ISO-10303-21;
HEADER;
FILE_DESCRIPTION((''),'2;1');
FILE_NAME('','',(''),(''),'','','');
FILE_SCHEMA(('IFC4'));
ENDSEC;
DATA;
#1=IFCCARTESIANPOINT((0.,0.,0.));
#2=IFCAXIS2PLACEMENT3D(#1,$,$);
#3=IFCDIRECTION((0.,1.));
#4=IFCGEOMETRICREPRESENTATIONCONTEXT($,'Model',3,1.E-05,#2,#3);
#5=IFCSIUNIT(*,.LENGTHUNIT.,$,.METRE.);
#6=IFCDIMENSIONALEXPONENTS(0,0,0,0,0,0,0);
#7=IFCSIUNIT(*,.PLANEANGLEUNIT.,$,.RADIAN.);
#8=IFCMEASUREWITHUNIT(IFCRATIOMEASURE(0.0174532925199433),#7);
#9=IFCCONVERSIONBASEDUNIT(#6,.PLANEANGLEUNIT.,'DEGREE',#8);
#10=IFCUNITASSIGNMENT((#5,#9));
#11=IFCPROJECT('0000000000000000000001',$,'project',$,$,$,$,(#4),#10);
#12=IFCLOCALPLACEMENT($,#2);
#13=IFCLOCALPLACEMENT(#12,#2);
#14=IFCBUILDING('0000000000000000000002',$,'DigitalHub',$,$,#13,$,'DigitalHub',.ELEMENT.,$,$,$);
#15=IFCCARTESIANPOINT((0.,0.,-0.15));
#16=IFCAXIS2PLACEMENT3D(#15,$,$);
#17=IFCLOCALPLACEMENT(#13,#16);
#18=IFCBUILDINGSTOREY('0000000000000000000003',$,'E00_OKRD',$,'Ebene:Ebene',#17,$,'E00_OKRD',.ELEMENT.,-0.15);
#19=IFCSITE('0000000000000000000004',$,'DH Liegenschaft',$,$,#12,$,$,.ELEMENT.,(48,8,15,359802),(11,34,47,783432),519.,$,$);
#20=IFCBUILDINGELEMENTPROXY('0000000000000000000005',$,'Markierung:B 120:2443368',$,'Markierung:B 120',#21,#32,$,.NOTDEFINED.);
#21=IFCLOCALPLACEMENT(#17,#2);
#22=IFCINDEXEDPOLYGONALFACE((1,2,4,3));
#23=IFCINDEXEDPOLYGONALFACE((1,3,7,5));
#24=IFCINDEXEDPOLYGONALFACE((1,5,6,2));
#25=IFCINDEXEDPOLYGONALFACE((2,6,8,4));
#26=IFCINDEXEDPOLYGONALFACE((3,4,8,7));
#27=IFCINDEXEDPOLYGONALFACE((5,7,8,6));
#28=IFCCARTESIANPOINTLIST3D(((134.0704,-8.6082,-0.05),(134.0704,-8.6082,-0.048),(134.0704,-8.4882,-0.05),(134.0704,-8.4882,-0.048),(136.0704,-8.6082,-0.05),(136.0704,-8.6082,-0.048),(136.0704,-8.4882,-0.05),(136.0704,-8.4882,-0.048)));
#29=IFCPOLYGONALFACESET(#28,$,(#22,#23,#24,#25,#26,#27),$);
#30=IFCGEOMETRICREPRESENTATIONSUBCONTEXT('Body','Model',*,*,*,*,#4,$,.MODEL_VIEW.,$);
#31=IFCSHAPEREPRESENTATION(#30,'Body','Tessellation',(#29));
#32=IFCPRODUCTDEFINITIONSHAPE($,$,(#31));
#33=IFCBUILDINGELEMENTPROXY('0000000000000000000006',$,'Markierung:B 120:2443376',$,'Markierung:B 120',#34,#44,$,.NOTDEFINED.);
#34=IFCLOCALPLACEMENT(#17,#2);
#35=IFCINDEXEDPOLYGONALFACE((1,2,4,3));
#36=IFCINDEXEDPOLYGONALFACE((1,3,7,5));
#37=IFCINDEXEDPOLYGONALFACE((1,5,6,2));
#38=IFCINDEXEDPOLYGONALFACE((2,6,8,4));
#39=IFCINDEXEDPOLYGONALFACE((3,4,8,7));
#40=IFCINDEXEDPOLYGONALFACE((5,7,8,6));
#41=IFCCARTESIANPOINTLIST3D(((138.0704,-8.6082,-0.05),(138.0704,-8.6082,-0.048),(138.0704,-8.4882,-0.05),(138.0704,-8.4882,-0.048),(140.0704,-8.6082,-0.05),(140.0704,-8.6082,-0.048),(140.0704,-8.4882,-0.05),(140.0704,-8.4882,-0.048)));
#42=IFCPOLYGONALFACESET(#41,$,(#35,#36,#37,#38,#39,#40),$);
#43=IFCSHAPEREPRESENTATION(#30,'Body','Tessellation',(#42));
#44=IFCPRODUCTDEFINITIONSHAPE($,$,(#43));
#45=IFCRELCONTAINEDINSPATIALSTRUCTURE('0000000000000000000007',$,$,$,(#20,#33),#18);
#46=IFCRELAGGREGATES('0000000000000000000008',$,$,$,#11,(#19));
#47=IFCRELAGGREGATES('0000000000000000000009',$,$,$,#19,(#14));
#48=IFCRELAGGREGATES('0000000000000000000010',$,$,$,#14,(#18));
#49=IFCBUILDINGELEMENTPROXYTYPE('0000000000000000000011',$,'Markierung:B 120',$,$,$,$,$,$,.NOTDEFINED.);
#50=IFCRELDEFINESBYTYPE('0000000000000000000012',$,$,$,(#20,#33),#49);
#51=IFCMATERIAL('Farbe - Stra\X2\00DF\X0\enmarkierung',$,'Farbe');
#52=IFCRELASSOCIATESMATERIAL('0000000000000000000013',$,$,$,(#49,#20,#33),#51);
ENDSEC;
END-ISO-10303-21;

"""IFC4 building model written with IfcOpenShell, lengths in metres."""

from ifc_helpers import new_model, entity, si_unit, converted_unit, direction, frame, origin, place, context, subcontext, project, spatial, indexed_curve, outline, extrude, source, transform, mapped, material, type_object, type_shapes, element, save


model = new_model("IFC4")

# Units and contexts
model_context = context("Model", 3, precision=1e-05, world=origin(), true_north=direction((0.0, 1.0)))
body_context = subcontext(model_context, "Body", "Model", "MODEL_VIEW")
ifc_project = project(units=[si_unit("LENGTHUNIT", "METRE"), converted_unit("PLANEANGLEUNIT", "DEGREE", entity("IfcRatioMeasure", 0.0174532925199433), si_unit("PLANEANGLEUNIT", "RADIAN"), dimensions=[0, 0, 0, 0, 0, 0, 0])], contexts=[model_context])

# Site, building, storey
site_placement = place(None, frame((0.0, 0.0, 0.0)))
site = spatial("IfcSite", under=ifc_project, at=site_placement, Name="DH Liegenschaft", CompositionType="ELEMENT", RefLatitude=(48, 8, 15, 359802), RefLongitude=(11, 34, 47, 783432), RefElevation=519.0)
building_placement = place(site_placement, origin())
building = spatial("IfcBuilding", under=site, at=building_placement, Name="DigitalHub", LongName="DigitalHub", CompositionType="ELEMENT")
storey_placement = place(building_placement, frame((0.0, 0.0, -0.15)))
storey = spatial("IfcBuildingStorey", under=building, at=storey_placement, Name="E00_OKRD", ObjectType="Ebene:Ebene", LongName="E00_OKRD", CompositionType="ELEMENT", Elevation=-0.15)

# Building element proxies
ifc_material_1 = material(Name="Farbe - Straßenmarkierung", Category="Farbe")
building_element_proxy_type_1 = type_object("IfcBuildingElementProxyType", Name="Markierung:B 120", PredefinedType="NOTDEFINED", material=ifc_material_1)
shared_shape_1 = source(origin(), body_context, "Body", "SweptSolid", [
    extrude(outline(indexed_curve([(-0.06, -1.0), (0.06, -1.0), (0.06, 1.0), (-0.06, 1.0), (-0.06, -1.0)], self_intersect=False)), frame((0.06, 1.0, 0.0), z_axis=(0.0, 0.0, 1.0), x_axis=(-1.0, 0.0, 0.0)), (0.0, 0.0, 1.0), 0.002),
])
type_shapes(building_element_proxy_type_1, [shared_shape_1])
for number, where, z_axis, x_axis, name in (
    (1, (136.0704, -8.6082, -0.05), (0.0, 0.0, 1.0), (0.0, 1.0, 0.0), "Markierung:B 120:2443368"),
    (2, (140.0704, -8.6082, -0.05), (0.0, 0.0, 1.0), (0.0, 1.0, 0.0), "Markierung:B 120:2443376"),
):
    element("IfcBuildingElementProxy", number, at=place(storey_placement, frame(where, z_axis=z_axis, x_axis=x_axis)), inside=storey, type_object=building_element_proxy_type_1, material=ifc_material_1, Name=name, ObjectType="Markierung:B 120", PredefinedType="NOTDEFINED", context=body_context, shape_type="MappedRepresentation", body=[
        mapped(shared_shape_1, transform((0.0, 0.0, 0.0), scale=1.0)),
    ])

save(model, "model.ifc")
